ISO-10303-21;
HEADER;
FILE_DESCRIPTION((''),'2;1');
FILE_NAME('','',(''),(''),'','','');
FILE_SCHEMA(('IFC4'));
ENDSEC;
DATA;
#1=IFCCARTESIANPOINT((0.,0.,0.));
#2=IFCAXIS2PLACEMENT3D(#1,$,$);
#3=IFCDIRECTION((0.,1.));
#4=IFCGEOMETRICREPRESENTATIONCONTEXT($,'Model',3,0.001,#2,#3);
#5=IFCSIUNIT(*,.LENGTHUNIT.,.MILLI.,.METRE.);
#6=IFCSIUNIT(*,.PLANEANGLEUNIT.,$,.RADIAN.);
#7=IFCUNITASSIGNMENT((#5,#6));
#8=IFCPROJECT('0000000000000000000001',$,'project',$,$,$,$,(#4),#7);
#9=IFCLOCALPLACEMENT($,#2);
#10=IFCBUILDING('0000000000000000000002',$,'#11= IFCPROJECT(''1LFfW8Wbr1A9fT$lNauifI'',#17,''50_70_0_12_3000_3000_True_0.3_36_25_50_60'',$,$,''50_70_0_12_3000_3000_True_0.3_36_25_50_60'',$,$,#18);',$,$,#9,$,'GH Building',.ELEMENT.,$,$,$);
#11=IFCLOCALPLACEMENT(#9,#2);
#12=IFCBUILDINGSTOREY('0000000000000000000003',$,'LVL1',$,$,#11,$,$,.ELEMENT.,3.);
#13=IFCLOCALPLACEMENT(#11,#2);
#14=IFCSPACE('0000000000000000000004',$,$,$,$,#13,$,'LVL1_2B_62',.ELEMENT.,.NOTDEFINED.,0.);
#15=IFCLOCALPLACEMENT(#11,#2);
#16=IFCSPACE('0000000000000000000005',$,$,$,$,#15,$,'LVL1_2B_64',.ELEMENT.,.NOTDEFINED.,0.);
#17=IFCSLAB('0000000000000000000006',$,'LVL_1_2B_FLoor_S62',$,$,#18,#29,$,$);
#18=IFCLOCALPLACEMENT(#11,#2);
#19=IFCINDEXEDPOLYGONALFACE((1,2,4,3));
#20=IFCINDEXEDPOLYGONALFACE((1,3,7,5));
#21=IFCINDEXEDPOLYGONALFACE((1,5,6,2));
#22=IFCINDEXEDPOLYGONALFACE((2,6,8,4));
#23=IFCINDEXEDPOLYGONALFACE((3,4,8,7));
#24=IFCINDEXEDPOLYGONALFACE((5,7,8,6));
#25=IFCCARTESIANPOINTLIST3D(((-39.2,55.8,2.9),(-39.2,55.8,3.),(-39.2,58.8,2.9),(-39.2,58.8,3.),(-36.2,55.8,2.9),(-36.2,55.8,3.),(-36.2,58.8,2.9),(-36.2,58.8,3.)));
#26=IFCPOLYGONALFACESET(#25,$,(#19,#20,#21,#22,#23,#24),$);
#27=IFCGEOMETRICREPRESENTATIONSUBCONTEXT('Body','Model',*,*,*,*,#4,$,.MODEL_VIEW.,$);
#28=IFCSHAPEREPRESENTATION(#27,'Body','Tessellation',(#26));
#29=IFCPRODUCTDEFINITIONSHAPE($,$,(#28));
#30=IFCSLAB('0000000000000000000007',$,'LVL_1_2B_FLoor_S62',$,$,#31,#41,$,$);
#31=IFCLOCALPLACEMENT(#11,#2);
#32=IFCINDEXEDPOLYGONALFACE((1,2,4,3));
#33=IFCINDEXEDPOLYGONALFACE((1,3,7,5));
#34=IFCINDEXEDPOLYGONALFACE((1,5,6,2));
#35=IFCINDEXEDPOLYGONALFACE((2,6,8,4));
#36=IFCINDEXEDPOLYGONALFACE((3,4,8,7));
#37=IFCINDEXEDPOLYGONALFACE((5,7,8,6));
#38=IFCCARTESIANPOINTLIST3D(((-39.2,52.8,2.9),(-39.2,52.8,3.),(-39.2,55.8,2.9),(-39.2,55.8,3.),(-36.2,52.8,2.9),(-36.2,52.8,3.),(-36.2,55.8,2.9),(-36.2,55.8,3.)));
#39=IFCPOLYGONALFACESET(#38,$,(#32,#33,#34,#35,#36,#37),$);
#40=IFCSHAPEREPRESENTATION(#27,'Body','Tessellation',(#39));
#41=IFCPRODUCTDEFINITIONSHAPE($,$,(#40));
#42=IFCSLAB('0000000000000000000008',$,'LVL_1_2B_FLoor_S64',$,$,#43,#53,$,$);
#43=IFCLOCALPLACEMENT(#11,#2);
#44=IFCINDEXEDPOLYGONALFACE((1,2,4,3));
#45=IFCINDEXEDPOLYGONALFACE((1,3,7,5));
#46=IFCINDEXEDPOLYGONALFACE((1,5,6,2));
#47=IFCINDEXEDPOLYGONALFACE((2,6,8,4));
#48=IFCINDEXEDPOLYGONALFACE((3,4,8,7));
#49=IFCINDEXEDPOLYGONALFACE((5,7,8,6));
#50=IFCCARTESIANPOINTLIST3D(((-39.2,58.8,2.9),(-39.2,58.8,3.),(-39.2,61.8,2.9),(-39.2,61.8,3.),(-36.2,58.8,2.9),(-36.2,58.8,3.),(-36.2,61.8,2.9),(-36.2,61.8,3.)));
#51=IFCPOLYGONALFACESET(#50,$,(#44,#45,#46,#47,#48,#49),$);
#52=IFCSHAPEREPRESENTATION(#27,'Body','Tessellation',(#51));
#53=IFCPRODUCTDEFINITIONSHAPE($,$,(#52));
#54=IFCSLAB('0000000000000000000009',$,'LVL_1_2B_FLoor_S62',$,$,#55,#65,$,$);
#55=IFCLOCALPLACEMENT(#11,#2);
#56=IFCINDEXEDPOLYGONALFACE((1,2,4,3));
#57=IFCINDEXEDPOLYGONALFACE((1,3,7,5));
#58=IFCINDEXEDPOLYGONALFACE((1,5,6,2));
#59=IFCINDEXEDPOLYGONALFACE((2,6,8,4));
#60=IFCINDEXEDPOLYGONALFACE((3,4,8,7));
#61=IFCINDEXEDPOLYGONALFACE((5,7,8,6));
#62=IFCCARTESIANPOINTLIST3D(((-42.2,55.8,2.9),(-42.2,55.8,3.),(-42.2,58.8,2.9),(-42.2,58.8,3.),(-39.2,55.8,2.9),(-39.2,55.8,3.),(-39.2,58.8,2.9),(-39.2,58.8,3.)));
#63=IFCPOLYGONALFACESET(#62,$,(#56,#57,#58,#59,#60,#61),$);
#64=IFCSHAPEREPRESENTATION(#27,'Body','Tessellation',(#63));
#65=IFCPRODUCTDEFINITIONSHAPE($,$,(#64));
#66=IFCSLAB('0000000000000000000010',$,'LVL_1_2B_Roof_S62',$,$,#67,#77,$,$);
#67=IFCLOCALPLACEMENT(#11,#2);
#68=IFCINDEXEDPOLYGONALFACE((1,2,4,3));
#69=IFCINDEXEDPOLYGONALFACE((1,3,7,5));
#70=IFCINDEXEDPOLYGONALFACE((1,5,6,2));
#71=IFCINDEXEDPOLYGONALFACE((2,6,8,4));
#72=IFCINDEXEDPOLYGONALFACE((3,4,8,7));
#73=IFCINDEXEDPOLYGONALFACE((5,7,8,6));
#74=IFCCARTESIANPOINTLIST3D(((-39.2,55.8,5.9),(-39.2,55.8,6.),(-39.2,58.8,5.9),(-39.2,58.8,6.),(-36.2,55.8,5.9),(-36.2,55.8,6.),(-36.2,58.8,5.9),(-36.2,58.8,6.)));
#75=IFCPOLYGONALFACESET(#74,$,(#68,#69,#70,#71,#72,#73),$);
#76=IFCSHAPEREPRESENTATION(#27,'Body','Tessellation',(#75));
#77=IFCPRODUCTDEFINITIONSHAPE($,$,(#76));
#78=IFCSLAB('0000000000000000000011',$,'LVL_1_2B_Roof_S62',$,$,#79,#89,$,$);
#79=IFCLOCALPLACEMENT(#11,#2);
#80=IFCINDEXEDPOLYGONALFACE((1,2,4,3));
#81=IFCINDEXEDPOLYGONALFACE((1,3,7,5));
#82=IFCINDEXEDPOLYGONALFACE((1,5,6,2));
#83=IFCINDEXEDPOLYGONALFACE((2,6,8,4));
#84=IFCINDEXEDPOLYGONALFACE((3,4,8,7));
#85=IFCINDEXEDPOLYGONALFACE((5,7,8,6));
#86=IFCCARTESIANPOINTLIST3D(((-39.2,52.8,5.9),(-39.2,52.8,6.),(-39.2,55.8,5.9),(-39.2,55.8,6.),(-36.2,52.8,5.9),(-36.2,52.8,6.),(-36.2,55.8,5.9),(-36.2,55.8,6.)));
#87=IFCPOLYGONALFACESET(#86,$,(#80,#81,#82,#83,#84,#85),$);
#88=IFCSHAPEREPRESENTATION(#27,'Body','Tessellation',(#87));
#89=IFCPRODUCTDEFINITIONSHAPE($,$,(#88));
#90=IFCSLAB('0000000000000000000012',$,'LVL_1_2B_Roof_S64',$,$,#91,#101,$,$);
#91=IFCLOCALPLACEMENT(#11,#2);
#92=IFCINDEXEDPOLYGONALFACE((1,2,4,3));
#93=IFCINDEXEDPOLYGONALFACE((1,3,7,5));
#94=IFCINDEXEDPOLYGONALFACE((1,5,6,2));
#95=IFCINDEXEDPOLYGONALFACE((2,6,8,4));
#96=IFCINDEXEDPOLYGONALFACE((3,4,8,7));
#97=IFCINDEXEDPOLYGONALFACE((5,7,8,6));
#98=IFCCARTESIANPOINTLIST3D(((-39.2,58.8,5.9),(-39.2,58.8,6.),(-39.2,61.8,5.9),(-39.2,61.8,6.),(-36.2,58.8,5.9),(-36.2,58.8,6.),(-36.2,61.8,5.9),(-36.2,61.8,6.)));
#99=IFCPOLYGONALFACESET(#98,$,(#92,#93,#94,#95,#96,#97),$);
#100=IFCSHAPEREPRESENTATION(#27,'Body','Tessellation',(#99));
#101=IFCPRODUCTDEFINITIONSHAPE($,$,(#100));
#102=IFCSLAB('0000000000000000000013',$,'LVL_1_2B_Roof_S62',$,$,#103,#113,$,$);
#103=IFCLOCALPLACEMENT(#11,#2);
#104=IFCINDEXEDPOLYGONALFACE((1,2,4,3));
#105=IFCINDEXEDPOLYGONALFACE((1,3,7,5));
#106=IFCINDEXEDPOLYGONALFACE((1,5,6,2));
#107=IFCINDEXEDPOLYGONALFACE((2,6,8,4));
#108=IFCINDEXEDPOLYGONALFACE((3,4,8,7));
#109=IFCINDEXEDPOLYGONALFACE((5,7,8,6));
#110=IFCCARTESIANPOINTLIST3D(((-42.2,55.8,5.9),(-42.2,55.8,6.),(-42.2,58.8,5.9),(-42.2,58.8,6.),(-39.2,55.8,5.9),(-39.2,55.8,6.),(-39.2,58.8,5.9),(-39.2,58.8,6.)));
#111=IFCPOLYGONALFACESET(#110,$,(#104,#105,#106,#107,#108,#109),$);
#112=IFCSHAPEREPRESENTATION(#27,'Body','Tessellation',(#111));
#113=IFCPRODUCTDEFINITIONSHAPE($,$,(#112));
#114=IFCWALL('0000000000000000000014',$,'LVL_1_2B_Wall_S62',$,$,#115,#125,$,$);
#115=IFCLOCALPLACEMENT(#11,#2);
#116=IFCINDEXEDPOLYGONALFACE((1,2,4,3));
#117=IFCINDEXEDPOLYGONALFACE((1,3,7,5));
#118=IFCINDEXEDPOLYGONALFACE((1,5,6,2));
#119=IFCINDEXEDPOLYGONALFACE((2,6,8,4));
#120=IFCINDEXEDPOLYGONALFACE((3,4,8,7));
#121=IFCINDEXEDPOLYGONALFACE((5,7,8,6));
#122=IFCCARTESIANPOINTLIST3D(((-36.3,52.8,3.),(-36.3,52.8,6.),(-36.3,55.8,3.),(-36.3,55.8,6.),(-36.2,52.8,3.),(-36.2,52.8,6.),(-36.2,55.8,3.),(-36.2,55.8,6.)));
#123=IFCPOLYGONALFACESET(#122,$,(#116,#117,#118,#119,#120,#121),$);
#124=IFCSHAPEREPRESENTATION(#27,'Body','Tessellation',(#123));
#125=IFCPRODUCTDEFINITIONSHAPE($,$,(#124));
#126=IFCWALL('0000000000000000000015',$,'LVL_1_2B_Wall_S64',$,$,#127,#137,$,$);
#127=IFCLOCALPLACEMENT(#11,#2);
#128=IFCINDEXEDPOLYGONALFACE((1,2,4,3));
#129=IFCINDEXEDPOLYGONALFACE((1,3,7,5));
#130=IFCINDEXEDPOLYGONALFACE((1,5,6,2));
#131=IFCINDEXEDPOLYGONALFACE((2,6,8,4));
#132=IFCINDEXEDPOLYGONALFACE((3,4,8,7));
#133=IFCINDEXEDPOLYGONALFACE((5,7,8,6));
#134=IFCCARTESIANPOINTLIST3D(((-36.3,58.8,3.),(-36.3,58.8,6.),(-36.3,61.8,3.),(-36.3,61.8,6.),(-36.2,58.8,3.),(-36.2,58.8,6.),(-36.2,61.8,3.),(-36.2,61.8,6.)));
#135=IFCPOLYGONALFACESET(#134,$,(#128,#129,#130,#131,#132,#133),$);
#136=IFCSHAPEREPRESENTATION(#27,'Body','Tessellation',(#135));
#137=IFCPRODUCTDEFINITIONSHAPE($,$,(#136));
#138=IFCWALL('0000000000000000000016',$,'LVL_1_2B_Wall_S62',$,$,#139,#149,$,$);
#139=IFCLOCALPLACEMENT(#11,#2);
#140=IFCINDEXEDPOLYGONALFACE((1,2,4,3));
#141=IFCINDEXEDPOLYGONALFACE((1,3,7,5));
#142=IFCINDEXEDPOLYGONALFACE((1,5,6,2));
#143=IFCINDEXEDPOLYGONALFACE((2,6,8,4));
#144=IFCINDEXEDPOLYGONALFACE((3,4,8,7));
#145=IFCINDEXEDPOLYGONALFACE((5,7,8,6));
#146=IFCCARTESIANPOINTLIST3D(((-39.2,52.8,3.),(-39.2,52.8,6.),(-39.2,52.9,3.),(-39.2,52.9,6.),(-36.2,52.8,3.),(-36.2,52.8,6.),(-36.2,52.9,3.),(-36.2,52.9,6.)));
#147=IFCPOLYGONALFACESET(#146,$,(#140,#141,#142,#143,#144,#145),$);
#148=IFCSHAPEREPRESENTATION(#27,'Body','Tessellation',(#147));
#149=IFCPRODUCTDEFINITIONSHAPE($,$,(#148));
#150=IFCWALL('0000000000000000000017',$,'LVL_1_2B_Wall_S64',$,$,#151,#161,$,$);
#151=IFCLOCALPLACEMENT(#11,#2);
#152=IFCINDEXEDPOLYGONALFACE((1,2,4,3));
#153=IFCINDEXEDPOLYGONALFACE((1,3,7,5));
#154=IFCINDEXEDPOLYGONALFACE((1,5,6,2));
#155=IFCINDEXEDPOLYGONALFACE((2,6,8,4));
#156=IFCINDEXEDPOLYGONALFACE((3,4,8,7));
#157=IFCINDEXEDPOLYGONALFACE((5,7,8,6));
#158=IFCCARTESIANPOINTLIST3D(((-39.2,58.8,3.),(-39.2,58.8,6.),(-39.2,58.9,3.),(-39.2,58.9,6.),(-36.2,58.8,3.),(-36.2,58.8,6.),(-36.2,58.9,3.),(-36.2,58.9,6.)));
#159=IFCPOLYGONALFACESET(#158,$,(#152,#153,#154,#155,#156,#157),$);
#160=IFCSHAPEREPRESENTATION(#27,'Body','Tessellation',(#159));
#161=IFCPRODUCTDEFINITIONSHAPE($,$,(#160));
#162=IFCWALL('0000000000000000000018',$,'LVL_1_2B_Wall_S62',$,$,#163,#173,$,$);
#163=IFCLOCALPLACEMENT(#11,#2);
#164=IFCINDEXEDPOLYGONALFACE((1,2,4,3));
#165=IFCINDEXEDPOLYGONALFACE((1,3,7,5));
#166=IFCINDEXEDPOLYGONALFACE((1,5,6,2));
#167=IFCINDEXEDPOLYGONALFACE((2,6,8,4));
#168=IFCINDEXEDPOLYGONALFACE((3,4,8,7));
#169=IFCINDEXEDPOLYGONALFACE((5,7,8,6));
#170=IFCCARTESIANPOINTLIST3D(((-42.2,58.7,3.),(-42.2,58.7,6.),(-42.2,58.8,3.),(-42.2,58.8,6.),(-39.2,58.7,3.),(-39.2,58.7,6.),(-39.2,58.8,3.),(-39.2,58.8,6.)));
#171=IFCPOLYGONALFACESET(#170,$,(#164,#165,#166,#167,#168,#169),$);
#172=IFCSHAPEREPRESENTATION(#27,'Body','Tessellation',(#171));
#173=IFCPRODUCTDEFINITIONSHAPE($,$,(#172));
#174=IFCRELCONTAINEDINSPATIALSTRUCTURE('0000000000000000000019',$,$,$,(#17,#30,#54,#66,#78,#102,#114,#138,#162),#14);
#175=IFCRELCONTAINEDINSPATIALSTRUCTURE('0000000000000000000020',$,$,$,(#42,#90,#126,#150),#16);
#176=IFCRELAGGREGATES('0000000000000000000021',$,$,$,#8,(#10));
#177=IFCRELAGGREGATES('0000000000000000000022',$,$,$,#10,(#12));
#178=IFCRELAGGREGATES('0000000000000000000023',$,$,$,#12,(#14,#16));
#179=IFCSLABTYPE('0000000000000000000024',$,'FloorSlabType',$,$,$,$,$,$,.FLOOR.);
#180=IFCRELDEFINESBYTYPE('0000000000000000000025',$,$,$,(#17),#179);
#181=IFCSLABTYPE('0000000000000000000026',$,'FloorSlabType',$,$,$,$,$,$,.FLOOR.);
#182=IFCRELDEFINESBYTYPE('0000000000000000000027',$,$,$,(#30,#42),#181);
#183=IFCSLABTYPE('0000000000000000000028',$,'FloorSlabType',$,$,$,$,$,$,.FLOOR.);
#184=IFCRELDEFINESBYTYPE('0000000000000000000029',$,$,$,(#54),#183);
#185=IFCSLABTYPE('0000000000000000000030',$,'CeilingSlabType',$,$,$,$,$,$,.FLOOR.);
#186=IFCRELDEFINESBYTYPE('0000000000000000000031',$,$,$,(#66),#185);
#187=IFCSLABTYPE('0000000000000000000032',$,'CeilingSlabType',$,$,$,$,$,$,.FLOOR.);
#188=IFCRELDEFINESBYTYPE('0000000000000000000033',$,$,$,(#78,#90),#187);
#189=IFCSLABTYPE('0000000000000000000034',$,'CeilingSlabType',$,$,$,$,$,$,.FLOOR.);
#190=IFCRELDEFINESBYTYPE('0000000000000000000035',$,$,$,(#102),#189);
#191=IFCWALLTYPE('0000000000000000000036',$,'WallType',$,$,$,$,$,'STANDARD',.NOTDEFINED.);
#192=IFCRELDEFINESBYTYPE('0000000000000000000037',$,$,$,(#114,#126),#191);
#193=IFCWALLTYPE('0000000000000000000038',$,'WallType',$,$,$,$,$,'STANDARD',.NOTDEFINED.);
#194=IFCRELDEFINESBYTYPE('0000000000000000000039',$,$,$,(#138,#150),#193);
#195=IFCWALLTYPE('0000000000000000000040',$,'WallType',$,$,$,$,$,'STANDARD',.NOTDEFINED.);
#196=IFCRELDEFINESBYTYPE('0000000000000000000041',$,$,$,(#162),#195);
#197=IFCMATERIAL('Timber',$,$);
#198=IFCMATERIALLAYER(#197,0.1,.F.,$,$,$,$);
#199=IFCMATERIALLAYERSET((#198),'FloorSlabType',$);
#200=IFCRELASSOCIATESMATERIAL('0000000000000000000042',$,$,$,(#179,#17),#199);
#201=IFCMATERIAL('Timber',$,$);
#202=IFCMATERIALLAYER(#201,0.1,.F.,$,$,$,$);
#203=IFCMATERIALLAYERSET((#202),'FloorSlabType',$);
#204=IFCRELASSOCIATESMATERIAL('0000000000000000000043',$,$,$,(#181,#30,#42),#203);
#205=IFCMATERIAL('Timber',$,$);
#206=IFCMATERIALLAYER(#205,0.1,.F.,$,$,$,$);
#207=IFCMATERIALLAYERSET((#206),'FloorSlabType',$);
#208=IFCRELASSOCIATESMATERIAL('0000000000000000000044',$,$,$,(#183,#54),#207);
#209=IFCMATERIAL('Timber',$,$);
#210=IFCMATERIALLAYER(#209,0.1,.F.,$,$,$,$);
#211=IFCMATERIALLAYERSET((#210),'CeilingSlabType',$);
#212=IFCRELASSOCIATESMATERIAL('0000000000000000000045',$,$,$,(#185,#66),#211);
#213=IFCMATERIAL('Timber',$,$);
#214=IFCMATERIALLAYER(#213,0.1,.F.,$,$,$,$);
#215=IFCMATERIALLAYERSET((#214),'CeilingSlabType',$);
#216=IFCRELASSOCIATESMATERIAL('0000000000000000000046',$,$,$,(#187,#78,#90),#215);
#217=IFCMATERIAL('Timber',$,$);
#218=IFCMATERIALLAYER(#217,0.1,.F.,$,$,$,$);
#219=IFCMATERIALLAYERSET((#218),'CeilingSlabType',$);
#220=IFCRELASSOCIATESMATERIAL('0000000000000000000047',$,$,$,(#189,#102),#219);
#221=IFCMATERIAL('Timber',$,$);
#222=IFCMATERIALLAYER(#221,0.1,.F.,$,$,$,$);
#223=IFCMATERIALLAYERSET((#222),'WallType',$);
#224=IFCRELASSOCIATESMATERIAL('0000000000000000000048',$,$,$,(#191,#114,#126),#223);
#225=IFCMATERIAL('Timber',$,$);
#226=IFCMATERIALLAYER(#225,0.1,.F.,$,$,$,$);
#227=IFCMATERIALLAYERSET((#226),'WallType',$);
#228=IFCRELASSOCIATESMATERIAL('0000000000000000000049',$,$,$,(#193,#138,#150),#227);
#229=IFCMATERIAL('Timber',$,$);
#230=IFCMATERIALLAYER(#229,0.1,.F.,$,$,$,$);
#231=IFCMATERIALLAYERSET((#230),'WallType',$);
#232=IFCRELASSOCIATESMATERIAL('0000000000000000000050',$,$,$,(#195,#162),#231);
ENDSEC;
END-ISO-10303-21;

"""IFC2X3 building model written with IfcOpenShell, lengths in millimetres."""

from ifc_helpers import new_model, si_unit, direction, frame, frame_2d, origin, place, context, subcontext, project, spatial, rectangle, extrude, material, layer, layer_set, layer_usage, type_object, element, save


model = new_model("IFC2X3")

# Units and contexts
model_context = context("Model", 3, precision=0.001, world=origin(), true_north=direction((0.0, 1.0)))
body_context = subcontext(model_context, "Body", "Model", "MODEL_VIEW")
ifc_project = project(units=[si_unit("LENGTHUNIT", "METRE", prefix="MILLI"), si_unit("PLANEANGLEUNIT", "RADIAN")], contexts=[model_context])

# Building, storey
building_placement = place(None, origin())
building = spatial("IfcBuilding", under=ifc_project, at=building_placement, Name="#11= IFCPROJECT('1LFfW8Wbr1A9fT$lNauifI',#17,'50_70_0_12_3000_3000_True_0.3_36_25_50_60',$,$,'50_70_0_12_3000_3000_True_0.3_36_25_50_60',$,$,#18);", LongName="GH Building", CompositionType="ELEMENT")
storey_placement = place(building_placement, origin())
storey = spatial("IfcBuildingStorey", under=building, at=storey_placement, Name="LVL1", CompositionType="ELEMENT", Elevation=3.0)

# Shared definitions
space_1_placement = place(storey_placement, origin())
space_1 = spatial("IfcSpace", under=storey, at=space_1_placement, LongName="LVL1_2B_62", CompositionType="ELEMENT", InteriorOrExteriorSpace="NOTDEFINED", ElevationWithFlooring=0.0)

# Slabs
ifc_material_1 = material(Name="Timber")
ifc_layer_1 = layer(ifc_material_1, 0.1, ventilated=False)
ifc_layer_set_1 = layer_set([ifc_layer_1], Name="FloorSlabType")
ifc_layer_usage_1 = layer_usage(ifc_layer_set_1, "AXIS3", "NEGATIVE", -0.1)
slab_type_1 = type_object("IfcSlabType", Name="FloorSlabType", PredefinedType="FLOOR", material=ifc_layer_set_1)
slab_1_placement = place(space_1_placement, frame((-39.2, 58.8, 2.9), z_axis=(0.0, 0.0, 1.0), x_axis=(0.0, -1.0, 0.0)))
element("IfcSlab", 1, at=slab_1_placement, inside=space_1, type_object=slab_type_1, material=ifc_layer_usage_1, Name="LVL_1_2B_FLoor_S62", context=body_context, shape_type="SweptSolid", body=[
    extrude(rectangle(XDim=3.0, YDim=3.0, at=frame_2d((1.5, 1.5))), origin(), (0.0, 0.0, 1.0), 0.1),
])
ifc_material_2 = material(Name="Timber")
ifc_layer_2 = layer(ifc_material_2, 0.1, ventilated=False)
ifc_layer_set_2 = layer_set([ifc_layer_2], Name="FloorSlabType")
ifc_layer_usage_2 = layer_usage(ifc_layer_set_2, "AXIS3", "NEGATIVE", -0.1)
slab_type_2 = type_object("IfcSlabType", Name="FloorSlabType", PredefinedType="FLOOR", material=ifc_layer_set_2)
slab_2_placement = place(space_1_placement, frame((-39.2, 55.8, 2.9), z_axis=(0.0, 0.0, 1.0), x_axis=(0.0, -1.0, 0.0)))
element("IfcSlab", 2, at=slab_2_placement, inside=space_1, type_object=slab_type_2, material=ifc_layer_usage_2, Name="LVL_1_2B_FLoor_S62", context=body_context, shape_type="SweptSolid", body=[
    extrude(rectangle(XDim=3.0, YDim=3.0, at=frame_2d((1.5, 1.5))), origin(), (0.0, 0.0, 1.0), 0.1),
])

# Shared definitions
space_2_placement = place(storey_placement, origin())
space_2 = spatial("IfcSpace", under=storey, at=space_2_placement, LongName="LVL1_2B_64", CompositionType="ELEMENT", InteriorOrExteriorSpace="NOTDEFINED", ElevationWithFlooring=0.0)

# Slabs
ifc_layer_usage_3 = layer_usage(ifc_layer_set_2, "AXIS3", "NEGATIVE", -0.1)
slab_3_placement = place(space_2_placement, frame((-39.2, 61.8, 2.9), z_axis=(0.0, 0.0, 1.0), x_axis=(0.0, -1.0, 0.0)))
element("IfcSlab", 3, at=slab_3_placement, inside=space_2, type_object=slab_type_2, material=ifc_layer_usage_3, Name="LVL_1_2B_FLoor_S64", context=body_context, shape_type="SweptSolid", body=[
    extrude(rectangle(XDim=3.0, YDim=3.0, at=frame_2d((1.5, 1.5))), origin(), (0.0, 0.0, 1.0), 0.1),
])
ifc_material_3 = material(Name="Timber")
ifc_layer_3 = layer(ifc_material_3, 0.1, ventilated=False)
ifc_layer_set_3 = layer_set([ifc_layer_3], Name="FloorSlabType")
ifc_layer_usage_4 = layer_usage(ifc_layer_set_3, "AXIS3", "NEGATIVE", -0.1)
slab_type_3 = type_object("IfcSlabType", Name="FloorSlabType", PredefinedType="FLOOR", material=ifc_layer_set_3)
slab_4_placement = place(space_1_placement, frame((-42.2, 58.8, 2.9), z_axis=(0.0, 0.0, 1.0), x_axis=(0.0, -1.0, 0.0)))
element("IfcSlab", 4, at=slab_4_placement, inside=space_1, type_object=slab_type_3, material=ifc_layer_usage_4, Name="LVL_1_2B_FLoor_S62", context=body_context, shape_type="SweptSolid", body=[
    extrude(rectangle(XDim=3.0, YDim=3.0, at=frame_2d((1.5, 1.5))), origin(), (0.0, 0.0, 1.0), 0.1),
])
ifc_material_4 = material(Name="Timber")
ifc_layer_4 = layer(ifc_material_4, 0.1, ventilated=False)
ifc_layer_set_4 = layer_set([ifc_layer_4], Name="CeilingSlabType")
ifc_layer_usage_5 = layer_usage(ifc_layer_set_4, "AXIS3", "NEGATIVE", -0.1)
slab_type_4 = type_object("IfcSlabType", Name="CeilingSlabType", PredefinedType="FLOOR", material=ifc_layer_set_4)
slab_5_placement = place(space_1_placement, frame((-39.2, 58.8, 5.9), z_axis=(0.0, 0.0, 1.0), x_axis=(0.0, -1.0, 0.0)))
element("IfcSlab", 5, at=slab_5_placement, inside=space_1, type_object=slab_type_4, material=ifc_layer_usage_5, Name="LVL_1_2B_Roof_S62", context=body_context, shape_type="SweptSolid", body=[
    extrude(rectangle(XDim=3.0, YDim=3.0, at=frame_2d((1.5, 1.5))), origin(), (0.0, 0.0, 1.0), 0.1),
])
ifc_material_5 = material(Name="Timber")
ifc_layer_5 = layer(ifc_material_5, 0.1, ventilated=False)
ifc_layer_set_5 = layer_set([ifc_layer_5], Name="CeilingSlabType")
ifc_layer_usage_6 = layer_usage(ifc_layer_set_5, "AXIS3", "NEGATIVE", -0.1)
slab_type_5 = type_object("IfcSlabType", Name="CeilingSlabType", PredefinedType="FLOOR", material=ifc_layer_set_5)
slab_6_placement = place(space_1_placement, frame((-39.2, 55.8, 5.9), z_axis=(0.0, 0.0, 1.0), x_axis=(0.0, -1.0, 0.0)))
element("IfcSlab", 6, at=slab_6_placement, inside=space_1, type_object=slab_type_5, material=ifc_layer_usage_6, Name="LVL_1_2B_Roof_S62", context=body_context, shape_type="SweptSolid", body=[
    extrude(rectangle(XDim=3.0, YDim=3.0, at=frame_2d((1.5, 1.5))), origin(), (0.0, 0.0, 1.0), 0.1),
])
ifc_layer_usage_7 = layer_usage(ifc_layer_set_5, "AXIS3", "NEGATIVE", -0.1)
slab_7_placement = place(space_2_placement, frame((-39.2, 61.8, 5.9), z_axis=(0.0, 0.0, 1.0), x_axis=(0.0, -1.0, 0.0)))
element("IfcSlab", 7, at=slab_7_placement, inside=space_2, type_object=slab_type_5, material=ifc_layer_usage_7, Name="LVL_1_2B_Roof_S64", context=body_context, shape_type="SweptSolid", body=[
    extrude(rectangle(XDim=3.0, YDim=3.0, at=frame_2d((1.5, 1.5))), origin(), (0.0, 0.0, 1.0), 0.1),
])
ifc_material_6 = material(Name="Timber")
ifc_layer_6 = layer(ifc_material_6, 0.1, ventilated=False)
ifc_layer_set_6 = layer_set([ifc_layer_6], Name="CeilingSlabType")
ifc_layer_usage_8 = layer_usage(ifc_layer_set_6, "AXIS3", "NEGATIVE", -0.1)
slab_type_6 = type_object("IfcSlabType", Name="CeilingSlabType", PredefinedType="FLOOR", material=ifc_layer_set_6)
slab_8_placement = place(space_1_placement, frame((-42.2, 58.8, 5.9), z_axis=(0.0, 0.0, 1.0), x_axis=(0.0, -1.0, 0.0)))
element("IfcSlab", 8, at=slab_8_placement, inside=space_1, type_object=slab_type_6, material=ifc_layer_usage_8, Name="LVL_1_2B_Roof_S62", context=body_context, shape_type="SweptSolid", body=[
    extrude(rectangle(XDim=3.0, YDim=3.0, at=frame_2d((1.5, 1.5))), origin(), (0.0, 0.0, 1.0), 0.1),
])

# Walls
ifc_material_7 = material(Name="Timber")
ifc_layer_7 = layer(ifc_material_7, 0.1, ventilated=False)
ifc_layer_set_7 = layer_set([ifc_layer_7], Name="WallType")
ifc_layer_usage_9 = layer_usage(ifc_layer_set_7, "AXIS2", "NEGATIVE", 0.0)
wall_type_1 = type_object("IfcWallType", Name="WallType", ElementType="STANDARD", PredefinedType="NOTDEFINED", material=ifc_layer_set_7)
wall_1_placement = place(space_1_placement, frame((-36.2, 55.8, 3.0), z_axis=(0.0, 0.0, 1.0), x_axis=(0.0, -1.0, 0.0)))
element("IfcWall", 9, at=wall_1_placement, inside=space_1, type_object=wall_type_1, material=ifc_layer_usage_9, Name="LVL_1_2B_Wall_S62", context=body_context, shape_type="SweptSolid", body=[
    extrude(rectangle(XDim=3.0, YDim=0.1, at=frame_2d((1.5, -0.1))), origin(), (0.0, 0.0, 1.0), 3.0),
])
ifc_layer_usage_10 = layer_usage(ifc_layer_set_7, "AXIS2", "NEGATIVE", 0.0)
wall_2_placement = place(space_2_placement, frame((-36.2, 61.8, 3.0), z_axis=(0.0, 0.0, 1.0), x_axis=(0.0, -1.0, 0.0)))
element("IfcWall", 10, at=wall_2_placement, inside=space_2, type_object=wall_type_1, material=ifc_layer_usage_10, Name="LVL_1_2B_Wall_S64", context=body_context, shape_type="SweptSolid", body=[
    extrude(rectangle(XDim=3.0, YDim=0.1, at=frame_2d((1.5, -0.1))), origin(), (0.0, 0.0, 1.0), 3.0),
])
ifc_material_8 = material(Name="Timber")
ifc_layer_8 = layer(ifc_material_8, 0.1, ventilated=False)
ifc_layer_set_8 = layer_set([ifc_layer_8], Name="WallType")
ifc_layer_usage_11 = layer_usage(ifc_layer_set_8, "AXIS2", "NEGATIVE", 0.0)
wall_type_2 = type_object("IfcWallType", Name="WallType", ElementType="STANDARD", PredefinedType="NOTDEFINED", material=ifc_layer_set_8)
wall_3_placement = place(space_1_placement, frame((-36.2, 52.8, 3.0), z_axis=(0.0, 0.0, 1.0), x_axis=(-1.0, 0.0, 0.0)))
element("IfcWall", 11, at=wall_3_placement, inside=space_1, type_object=wall_type_2, material=ifc_layer_usage_11, Name="LVL_1_2B_Wall_S62", context=body_context, shape_type="SweptSolid", body=[
    extrude(rectangle(XDim=3.0, YDim=0.1, at=frame_2d((1.5, -0.1))), origin(), (0.0, 0.0, 1.0), 3.0),
])
ifc_layer_usage_12 = layer_usage(ifc_layer_set_8, "AXIS2", "NEGATIVE", 0.0)
wall_4_placement = place(space_2_placement, frame((-36.2, 58.8, 3.0), z_axis=(0.0, 0.0, 1.0), x_axis=(-1.0, 0.0, 0.0)))
element("IfcWall", 12, at=wall_4_placement, inside=space_2, type_object=wall_type_2, material=ifc_layer_usage_12, Name="LVL_1_2B_Wall_S64", context=body_context, shape_type="SweptSolid", body=[
    extrude(rectangle(XDim=3.0, YDim=0.1, at=frame_2d((1.5, -0.1))), origin(), (0.0, 0.0, 1.0), 3.0),
])
ifc_material_9 = material(Name="Timber")
ifc_layer_9 = layer(ifc_material_9, 0.1, ventilated=False)
ifc_layer_set_9 = layer_set([ifc_layer_9], Name="WallType")
ifc_layer_usage_13 = layer_usage(ifc_layer_set_9, "AXIS2", "NEGATIVE", 0.0)
wall_type_3 = type_object("IfcWallType", Name="WallType", ElementType="STANDARD", PredefinedType="NOTDEFINED", material=ifc_layer_set_9)
wall_5_placement = place(space_1_placement, frame((-42.2, 58.8, 3.0)))
element("IfcWall", 13, at=wall_5_placement, inside=space_1, type_object=wall_type_3, material=ifc_layer_usage_13, Name="LVL_1_2B_Wall_S62", context=body_context, shape_type="SweptSolid", body=[
    extrude(rectangle(XDim=3.0, YDim=0.1, at=frame_2d((1.5, -0.1))), origin(), (0.0, 0.0, 1.0), 3.0),
])

save(model, "model.ifc")
